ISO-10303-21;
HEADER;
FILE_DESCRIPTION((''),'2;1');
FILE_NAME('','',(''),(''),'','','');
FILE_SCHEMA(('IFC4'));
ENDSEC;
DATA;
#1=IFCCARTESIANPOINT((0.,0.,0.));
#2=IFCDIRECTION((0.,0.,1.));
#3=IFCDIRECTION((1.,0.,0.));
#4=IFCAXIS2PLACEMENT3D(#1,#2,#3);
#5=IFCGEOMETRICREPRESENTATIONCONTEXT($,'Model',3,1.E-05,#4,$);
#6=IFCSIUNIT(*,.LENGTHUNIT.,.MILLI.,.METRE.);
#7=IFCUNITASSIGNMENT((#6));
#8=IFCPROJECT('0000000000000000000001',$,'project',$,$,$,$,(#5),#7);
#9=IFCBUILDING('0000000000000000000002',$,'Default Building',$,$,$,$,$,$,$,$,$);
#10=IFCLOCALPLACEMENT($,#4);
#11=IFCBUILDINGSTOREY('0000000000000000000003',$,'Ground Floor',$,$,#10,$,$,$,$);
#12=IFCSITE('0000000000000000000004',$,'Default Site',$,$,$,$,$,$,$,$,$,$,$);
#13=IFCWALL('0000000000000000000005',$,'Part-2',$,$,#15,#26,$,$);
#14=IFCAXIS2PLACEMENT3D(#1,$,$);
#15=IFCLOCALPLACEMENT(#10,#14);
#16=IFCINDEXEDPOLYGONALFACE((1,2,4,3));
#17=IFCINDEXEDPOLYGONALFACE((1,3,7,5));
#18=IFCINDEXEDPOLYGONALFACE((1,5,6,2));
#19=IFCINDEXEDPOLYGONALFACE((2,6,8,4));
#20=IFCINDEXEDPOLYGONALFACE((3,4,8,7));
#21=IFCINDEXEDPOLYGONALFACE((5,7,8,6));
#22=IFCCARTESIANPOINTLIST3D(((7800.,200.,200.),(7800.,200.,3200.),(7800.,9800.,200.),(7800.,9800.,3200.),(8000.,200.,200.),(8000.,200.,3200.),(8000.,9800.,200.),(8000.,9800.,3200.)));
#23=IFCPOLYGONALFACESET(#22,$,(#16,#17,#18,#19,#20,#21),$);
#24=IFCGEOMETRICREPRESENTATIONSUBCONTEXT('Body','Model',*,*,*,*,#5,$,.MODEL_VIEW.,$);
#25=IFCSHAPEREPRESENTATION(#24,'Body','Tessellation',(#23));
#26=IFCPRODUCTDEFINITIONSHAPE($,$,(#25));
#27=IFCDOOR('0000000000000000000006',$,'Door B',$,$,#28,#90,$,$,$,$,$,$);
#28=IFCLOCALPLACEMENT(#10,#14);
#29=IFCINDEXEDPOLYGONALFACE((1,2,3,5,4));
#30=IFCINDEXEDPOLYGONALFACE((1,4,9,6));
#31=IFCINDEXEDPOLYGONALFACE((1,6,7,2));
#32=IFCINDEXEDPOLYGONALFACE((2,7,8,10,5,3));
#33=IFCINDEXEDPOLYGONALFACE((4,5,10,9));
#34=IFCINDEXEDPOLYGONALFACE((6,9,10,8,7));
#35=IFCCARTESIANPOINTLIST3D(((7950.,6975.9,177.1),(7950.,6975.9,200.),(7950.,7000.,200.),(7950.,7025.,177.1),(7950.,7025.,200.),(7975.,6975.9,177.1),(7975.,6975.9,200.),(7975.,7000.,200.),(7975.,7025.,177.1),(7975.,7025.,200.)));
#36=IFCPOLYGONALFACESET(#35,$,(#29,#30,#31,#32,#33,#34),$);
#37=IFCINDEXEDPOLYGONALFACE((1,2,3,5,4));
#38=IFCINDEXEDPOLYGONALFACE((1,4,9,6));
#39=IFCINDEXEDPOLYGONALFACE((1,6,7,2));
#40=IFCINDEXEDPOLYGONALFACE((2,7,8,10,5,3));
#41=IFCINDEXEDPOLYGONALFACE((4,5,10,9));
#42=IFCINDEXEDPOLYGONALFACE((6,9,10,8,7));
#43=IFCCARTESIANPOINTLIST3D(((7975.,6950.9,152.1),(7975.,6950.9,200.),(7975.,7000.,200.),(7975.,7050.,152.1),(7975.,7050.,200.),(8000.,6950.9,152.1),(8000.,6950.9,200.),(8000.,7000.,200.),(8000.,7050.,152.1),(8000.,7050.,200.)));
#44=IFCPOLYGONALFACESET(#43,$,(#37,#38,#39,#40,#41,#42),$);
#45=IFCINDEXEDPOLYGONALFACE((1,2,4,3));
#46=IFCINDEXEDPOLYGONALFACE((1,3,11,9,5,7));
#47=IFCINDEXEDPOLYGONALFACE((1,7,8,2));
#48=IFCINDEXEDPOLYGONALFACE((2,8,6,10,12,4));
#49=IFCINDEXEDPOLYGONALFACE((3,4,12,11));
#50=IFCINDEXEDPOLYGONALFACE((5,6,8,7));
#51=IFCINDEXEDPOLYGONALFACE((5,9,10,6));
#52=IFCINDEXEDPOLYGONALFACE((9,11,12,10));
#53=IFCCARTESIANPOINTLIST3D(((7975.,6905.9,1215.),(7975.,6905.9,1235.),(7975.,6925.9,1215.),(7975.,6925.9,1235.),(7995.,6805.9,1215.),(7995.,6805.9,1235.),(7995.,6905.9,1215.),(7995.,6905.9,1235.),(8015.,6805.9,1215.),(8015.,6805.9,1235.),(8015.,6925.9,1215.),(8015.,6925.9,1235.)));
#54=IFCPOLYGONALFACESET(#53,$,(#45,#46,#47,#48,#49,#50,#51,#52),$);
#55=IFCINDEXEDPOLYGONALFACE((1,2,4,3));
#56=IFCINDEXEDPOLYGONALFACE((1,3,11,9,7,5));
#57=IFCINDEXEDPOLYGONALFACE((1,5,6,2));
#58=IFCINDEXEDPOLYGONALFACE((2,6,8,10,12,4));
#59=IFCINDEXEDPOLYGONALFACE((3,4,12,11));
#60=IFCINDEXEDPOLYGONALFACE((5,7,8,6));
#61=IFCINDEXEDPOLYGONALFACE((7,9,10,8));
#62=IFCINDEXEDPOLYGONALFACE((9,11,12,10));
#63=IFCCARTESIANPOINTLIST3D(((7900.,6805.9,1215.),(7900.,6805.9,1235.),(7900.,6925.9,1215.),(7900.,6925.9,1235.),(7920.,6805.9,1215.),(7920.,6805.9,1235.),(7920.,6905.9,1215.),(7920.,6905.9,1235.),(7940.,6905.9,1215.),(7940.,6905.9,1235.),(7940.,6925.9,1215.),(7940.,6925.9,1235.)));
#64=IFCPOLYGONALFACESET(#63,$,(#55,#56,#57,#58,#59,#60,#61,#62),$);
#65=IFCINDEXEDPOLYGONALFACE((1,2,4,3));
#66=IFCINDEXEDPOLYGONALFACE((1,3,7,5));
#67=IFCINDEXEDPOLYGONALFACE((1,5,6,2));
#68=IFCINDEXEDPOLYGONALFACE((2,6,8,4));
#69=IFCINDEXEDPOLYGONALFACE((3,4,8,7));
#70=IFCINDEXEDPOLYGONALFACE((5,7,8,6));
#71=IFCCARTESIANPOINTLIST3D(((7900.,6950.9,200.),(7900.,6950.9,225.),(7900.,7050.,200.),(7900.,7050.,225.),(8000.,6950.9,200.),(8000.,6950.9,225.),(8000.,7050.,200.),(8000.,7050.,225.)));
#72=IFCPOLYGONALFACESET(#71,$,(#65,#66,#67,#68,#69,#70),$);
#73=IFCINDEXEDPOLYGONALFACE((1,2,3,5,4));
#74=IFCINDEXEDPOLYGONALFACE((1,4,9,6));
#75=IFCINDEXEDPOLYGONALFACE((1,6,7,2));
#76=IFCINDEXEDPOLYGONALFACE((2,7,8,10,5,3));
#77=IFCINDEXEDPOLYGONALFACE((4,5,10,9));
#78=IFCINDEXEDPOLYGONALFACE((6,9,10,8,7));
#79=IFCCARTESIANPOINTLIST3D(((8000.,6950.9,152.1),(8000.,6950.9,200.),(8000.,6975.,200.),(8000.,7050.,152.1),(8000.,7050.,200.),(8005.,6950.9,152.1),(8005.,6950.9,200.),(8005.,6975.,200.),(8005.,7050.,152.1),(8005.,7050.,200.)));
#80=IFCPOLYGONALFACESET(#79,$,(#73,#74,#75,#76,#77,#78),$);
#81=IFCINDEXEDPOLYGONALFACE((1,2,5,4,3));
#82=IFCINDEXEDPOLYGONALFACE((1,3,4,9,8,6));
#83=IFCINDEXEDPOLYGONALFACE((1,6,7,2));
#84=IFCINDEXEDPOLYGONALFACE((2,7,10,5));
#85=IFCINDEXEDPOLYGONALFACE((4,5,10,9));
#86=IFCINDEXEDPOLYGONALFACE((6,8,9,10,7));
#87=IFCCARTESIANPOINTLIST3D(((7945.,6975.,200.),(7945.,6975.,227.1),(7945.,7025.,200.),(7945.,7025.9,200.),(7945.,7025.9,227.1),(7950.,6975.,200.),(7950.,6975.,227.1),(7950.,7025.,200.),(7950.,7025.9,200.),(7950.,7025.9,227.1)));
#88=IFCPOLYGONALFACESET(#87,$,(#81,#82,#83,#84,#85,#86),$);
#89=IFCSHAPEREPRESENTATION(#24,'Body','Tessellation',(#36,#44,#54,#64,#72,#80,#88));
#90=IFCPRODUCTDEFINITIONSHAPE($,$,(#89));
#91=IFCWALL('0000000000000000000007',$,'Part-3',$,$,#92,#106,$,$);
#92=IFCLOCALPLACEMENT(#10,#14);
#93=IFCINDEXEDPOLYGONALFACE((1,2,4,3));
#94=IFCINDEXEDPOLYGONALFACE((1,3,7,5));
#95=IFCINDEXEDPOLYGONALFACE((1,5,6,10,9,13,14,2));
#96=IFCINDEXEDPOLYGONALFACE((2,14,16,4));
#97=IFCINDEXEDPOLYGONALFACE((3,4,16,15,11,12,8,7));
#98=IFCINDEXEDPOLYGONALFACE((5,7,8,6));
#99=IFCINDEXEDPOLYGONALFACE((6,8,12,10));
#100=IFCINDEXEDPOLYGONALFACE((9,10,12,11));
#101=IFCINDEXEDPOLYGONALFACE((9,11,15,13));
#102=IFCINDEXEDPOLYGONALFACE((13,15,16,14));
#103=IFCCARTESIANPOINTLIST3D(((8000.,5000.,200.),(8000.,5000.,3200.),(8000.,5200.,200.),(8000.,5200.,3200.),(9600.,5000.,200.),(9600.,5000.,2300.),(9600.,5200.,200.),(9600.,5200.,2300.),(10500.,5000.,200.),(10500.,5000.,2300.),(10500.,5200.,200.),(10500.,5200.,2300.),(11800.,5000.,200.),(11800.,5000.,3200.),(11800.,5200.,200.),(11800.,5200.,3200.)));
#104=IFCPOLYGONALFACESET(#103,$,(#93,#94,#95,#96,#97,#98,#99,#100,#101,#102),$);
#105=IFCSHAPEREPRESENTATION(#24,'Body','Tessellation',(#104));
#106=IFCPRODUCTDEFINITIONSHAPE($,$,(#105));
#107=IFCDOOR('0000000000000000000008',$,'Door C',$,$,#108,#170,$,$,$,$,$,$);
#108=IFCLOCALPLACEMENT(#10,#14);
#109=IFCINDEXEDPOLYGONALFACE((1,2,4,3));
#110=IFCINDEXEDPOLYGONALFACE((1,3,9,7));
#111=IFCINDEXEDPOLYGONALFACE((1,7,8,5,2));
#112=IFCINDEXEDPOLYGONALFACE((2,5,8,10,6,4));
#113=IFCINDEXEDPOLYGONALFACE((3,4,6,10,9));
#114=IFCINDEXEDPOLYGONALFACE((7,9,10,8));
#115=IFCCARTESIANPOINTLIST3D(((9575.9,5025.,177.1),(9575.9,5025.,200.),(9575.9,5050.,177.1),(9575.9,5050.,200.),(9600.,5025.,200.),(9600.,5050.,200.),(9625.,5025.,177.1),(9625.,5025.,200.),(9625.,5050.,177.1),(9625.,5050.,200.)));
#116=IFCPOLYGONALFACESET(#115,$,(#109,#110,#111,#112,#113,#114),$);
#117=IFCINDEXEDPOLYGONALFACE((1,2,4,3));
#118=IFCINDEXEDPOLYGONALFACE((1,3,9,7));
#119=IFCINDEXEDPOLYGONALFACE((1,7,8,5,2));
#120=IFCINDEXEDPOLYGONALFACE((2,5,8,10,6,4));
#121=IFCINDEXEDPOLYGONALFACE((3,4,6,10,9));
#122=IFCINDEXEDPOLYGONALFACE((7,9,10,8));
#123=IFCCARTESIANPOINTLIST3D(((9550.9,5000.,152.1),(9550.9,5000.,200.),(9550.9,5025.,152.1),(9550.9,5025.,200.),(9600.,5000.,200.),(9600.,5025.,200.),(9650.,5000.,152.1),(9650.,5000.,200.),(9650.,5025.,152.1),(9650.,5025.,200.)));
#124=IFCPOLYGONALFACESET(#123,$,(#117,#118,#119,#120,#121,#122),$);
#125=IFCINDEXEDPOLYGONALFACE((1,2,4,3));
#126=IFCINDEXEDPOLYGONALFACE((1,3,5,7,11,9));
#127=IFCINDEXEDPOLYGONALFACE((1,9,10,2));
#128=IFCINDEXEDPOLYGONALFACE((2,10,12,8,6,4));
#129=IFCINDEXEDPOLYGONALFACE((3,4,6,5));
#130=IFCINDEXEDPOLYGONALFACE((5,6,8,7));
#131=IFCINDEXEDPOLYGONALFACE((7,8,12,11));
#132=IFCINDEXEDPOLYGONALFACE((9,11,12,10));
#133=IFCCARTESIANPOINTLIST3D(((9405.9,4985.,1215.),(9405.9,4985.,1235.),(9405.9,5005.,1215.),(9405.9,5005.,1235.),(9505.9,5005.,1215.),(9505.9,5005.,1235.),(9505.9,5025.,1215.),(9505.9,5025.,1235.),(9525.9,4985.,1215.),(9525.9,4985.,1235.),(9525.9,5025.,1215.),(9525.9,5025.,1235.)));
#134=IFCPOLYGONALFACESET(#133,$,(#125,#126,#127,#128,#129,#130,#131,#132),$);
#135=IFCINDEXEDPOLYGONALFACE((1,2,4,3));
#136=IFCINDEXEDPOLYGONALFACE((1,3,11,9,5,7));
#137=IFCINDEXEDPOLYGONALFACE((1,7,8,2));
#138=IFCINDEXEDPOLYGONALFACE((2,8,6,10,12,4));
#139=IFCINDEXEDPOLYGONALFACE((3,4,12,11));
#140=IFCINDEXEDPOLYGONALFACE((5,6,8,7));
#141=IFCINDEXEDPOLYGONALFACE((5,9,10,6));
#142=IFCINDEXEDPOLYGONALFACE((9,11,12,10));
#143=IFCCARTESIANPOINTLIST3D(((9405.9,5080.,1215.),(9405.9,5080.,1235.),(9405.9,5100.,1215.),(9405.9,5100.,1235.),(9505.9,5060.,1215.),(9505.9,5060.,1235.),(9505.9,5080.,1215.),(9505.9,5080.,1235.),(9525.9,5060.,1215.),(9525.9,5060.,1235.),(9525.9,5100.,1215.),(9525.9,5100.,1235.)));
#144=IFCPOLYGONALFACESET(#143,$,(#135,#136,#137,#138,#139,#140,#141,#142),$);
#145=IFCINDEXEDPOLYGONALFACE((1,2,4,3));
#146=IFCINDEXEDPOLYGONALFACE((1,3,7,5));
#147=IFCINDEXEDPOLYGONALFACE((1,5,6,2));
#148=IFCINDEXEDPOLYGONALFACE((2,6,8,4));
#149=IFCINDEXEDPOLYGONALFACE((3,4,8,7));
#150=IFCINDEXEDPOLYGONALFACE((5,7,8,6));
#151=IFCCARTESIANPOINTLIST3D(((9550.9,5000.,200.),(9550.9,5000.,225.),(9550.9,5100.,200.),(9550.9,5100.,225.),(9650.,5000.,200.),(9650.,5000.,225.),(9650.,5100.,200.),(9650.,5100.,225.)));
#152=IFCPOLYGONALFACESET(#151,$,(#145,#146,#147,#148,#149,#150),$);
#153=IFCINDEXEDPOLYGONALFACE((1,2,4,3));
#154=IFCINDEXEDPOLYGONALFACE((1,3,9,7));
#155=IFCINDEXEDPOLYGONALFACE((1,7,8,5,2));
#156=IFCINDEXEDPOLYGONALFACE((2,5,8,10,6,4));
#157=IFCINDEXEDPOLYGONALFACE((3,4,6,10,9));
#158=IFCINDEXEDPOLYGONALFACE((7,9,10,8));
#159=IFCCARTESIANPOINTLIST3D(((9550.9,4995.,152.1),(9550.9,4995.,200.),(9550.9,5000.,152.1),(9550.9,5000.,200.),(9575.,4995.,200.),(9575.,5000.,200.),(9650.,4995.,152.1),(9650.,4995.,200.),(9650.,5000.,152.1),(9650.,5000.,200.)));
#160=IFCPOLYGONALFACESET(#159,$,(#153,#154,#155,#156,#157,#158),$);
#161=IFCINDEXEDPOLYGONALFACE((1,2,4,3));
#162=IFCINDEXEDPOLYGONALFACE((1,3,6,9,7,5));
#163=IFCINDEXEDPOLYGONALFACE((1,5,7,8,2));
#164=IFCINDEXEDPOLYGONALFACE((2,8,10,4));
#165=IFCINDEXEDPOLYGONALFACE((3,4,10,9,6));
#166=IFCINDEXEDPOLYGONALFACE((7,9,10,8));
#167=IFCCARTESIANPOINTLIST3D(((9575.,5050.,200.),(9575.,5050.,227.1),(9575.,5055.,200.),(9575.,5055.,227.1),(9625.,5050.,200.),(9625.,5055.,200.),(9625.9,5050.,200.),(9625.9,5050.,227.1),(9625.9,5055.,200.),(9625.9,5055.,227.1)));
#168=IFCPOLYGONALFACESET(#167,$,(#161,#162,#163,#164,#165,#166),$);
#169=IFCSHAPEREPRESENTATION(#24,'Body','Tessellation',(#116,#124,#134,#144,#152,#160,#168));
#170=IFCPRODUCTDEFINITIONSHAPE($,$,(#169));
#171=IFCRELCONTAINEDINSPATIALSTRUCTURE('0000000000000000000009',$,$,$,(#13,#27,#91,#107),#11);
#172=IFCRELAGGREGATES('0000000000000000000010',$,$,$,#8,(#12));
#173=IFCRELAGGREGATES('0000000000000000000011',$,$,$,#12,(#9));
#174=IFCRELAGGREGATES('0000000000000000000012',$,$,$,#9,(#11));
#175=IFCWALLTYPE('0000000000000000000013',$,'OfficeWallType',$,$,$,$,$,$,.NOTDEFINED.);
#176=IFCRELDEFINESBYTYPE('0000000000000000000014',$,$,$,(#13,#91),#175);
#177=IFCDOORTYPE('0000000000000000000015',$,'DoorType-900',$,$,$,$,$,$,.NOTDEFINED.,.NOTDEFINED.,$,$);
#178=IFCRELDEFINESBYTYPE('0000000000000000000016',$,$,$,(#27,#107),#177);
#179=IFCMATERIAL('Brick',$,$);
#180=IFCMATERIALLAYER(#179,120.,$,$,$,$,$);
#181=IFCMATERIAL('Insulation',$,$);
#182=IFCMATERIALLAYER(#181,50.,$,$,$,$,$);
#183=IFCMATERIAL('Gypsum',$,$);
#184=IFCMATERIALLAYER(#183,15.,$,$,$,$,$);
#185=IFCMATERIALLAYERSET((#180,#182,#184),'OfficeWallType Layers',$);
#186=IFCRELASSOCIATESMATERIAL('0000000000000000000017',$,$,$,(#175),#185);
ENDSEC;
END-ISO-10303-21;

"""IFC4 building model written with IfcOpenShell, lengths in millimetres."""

from ifc_helpers import new_model, si_unit, frame, origin_with_axes, place, context, subcontext, project, spatial, line, indexed_curve, outline, extrude, material, layer, layer_set, type_object, element, fill, save


model = new_model("IFC4")

# Units and contexts
model_context = context("Model", 3, precision=1e-05, world=origin_with_axes())
body_context = subcontext(model_context, "Body", "Model", "MODEL_VIEW")
ifc_project = project(units=[si_unit("LENGTHUNIT", "METRE", prefix="MILLI")], contexts=[model_context])

# Site, building, storey
site = spatial("IfcSite", under=ifc_project, Name="Default Site")
building = spatial("IfcBuilding", under=site, Name="Default Building")
storey_placement = place(None, origin_with_axes())
storey = spatial("IfcBuildingStorey", under=building, at=storey_placement, Name="Ground Floor")

# Shared definitions
ifc_material_1 = material(Name="Brick")
ifc_layer_1 = layer(ifc_material_1, 120.0)
ifc_material_2 = material(Name="Insulation")
ifc_layer_2 = layer(ifc_material_2, 50.0)
ifc_material_3 = material(Name="Gypsum")
ifc_layer_3 = layer(ifc_material_3, 15.0)
ifc_layer_set_1 = layer_set([ifc_layer_1, ifc_layer_2, ifc_layer_3], Name="OfficeWallType Layers")
wall_type = type_object("IfcWallType", Name="OfficeWallType", PredefinedType="NOTDEFINED", material=ifc_layer_set_1)
door_type = type_object("IfcDoorType", Name="DoorType-900", OperationType="NOTDEFINED", PredefinedType="NOTDEFINED")

# Walls, openings, doors
wall_1_placement = place(storey_placement, frame((0.0, 0.0, 200.0), z_axis=(0.0, 0.0, 1.0), x_axis=(1.0, 0.0, 0.0)))
wall_1 = element("IfcWall", 1, at=wall_1_placement, inside=storey, type_object=wall_type, Name="Part-2", context=body_context, shape_type="SweptSolid", body=[
    extrude(outline(indexed_curve([(8000.0, 200.0), (8000.0, 9800.0), (7800.0, 9800.0), (7800.0, 200.0), (8000.0, 200.0)])), None, (0.0, 0.0, 1.0), 3000.0),
])
opening_1_placement = place(wall_1_placement, origin_with_axes())
opening_1 = element("IfcOpeningElement", 2, at=opening_1_placement, cuts=wall_1, context=body_context, shape_type="SweptSolid", body=[
    extrude(outline(indexed_curve([(8000.0, 7000.0), (8200.0, 7000.0), (8200.0, 7900.0), (8000.0, 7900.0), (8000.0, 7000.0)])), None, (0.0, 0.0, 1.0), 2100.0),
])
door_1_placement = place(storey_placement, frame((8000.0, 7000.0, 200.0), z_axis=(0.0, 0.0, 1.0), x_axis=(0.0, 1.0, 0.0)))
door_1 = element("IfcDoor", 3, at=door_1_placement, inside=storey, type_object=door_type, Name="Door B", context=body_context, shape_type="SweptSolid", body=[
    extrude(outline(indexed_curve([(0.0, 0.0), (0.0, 2.1), (0.9, 2.1), (0.9, 0.0), (-24.1, 0.0), (-24.1, -22.9), (25.0, -22.9), (25.0, 0.0)], segments=[line(1, 2, 3, 4, 5, 6, 7, 8, 1)])), frame((0.0, 25.0, 0.0), z_axis=(0.0, -1.0, 0.0), x_axis=(1.0, 0.0, 0.0)), (0.0, 0.0, -1.0), 25.0),
    extrude(outline(indexed_curve([(0.0, 0.0), (0.0, 2.1), (0.9, 2.1), (0.9, 0.0), (-49.1, 0.0), (-49.1, -47.9), (50.0, -47.9), (50.0, 0.0)], segments=[line(1, 2, 3, 4, 5, 6, 7, 8, 1)])), frame((0.0, 0.0, 0.0), z_axis=(0.0, -1.0, 0.0), x_axis=(1.0, 0.0, 0.0)), (0.0, 0.0, -1.0), 25.0),
    extrude(outline(indexed_curve([(0.0, 0.0), (-49.1, 0.0), (-49.1, 35.0), (0.0, 35.0)], segments=[line(1, 2, 3, 4, 1)])), frame((25.0, 25.0, 25.0), z_axis=(0.0, 0.0, 1.0), x_axis=(1.0, 0.0, 0.0)), (0.0, 0.0, 1.0), -47.9),
    extrude(outline(indexed_curve([(0.0, 0.0), (0.0, -40.0), (-120.0, -40.0), (-120.0, -20.0), (-20.0, -20.0), (-20.0, 0.0)], segments=[line(1, 2, 3, 4, 5, 6, 1)])), frame((-74.1, 25.0, 1015.0), z_axis=(0.0, 0.0, 1.0), x_axis=(1.0, 0.0, 0.0)), (0.0, 0.0, 1.0), 20.0),
    extrude(outline(indexed_curve([(0.0, 0.0), (0.0, 40.0), (-120.0, 40.0), (-120.0, 20.0), (-20.0, 20.0), (-20.0, 0.0)], segments=[line(1, 2, 3, 4, 5, 6, 1)])), frame((-74.1, 60.0, 1015.0), z_axis=(0.0, 0.0, 1.0), x_axis=(1.0, 0.0, 0.0)), (0.0, 0.0, 1.0), 20.0),
    extrude(outline(indexed_curve([(0.0, 0.0), (-99.1, 0.0), (-99.1, 100.0), (0.0, 100.0)], segments=[line(1, 2, 3, 4, 1)])), frame((50.0, 0.0, 0.0), z_axis=(0.0, 0.0, 1.0), x_axis=(1.0, 0.0, 0.0)), (0.0, 0.0, 1.0), 25.0),
    extrude(outline(indexed_curve([(0.0, 0.0), (0.0, 27.1), (50.9, 27.1), (50.9, 0.0), (-24.1, 0.0), (-24.1, -47.9), (75.0, -47.9), (75.0, 0.0)], segments=[line(1, 2, 3, 4, 5, 6, 7, 8, 1)])), frame((-25.0, -5.0, 0.0), z_axis=(0.0, -1.0, 0.0), x_axis=(1.0, 0.0, 0.0)), (0.0, 0.0, -1.0), 5.0),
    extrude(outline(indexed_curve([(0.0, 0.0), (0.0, 27.1), (50.9, 27.1), (50.9, 0.0), (0.9, 0.0), (0.9, -22.9), (50.0, -22.9), (50.0, 0.0)], segments=[line(1, 2, 3, 4, 5, 6, 7, 8, 1)])), frame((-25.0, 50.0, 0.0), z_axis=(0.0, -1.0, 0.0), x_axis=(1.0, 0.0, 0.0)), (0.0, 0.0, -1.0), 5.0),
])
fill(opening_1, door_1)
wall_2_placement = place(storey_placement, frame((0.0, 0.0, 200.0), z_axis=(0.0, 0.0, 1.0), x_axis=(1.0, 0.0, 0.0)))
wall_2 = element("IfcWall", 4, at=wall_2_placement, inside=storey, type_object=wall_type, Name="Part-3", context=body_context, shape_type="SweptSolid", body=[
    extrude(outline(indexed_curve([(8000.0, 5000.0), (11800.0, 5000.0), (11800.0, 5200.0), (8000.0, 5200.0), (8000.0, 5000.0)])), None, (0.0, 0.0, 1.0), 3000.0),
])
opening_2_placement = place(wall_2_placement, origin_with_axes())
opening_2 = element("IfcOpeningElement", 5, at=opening_2_placement, cuts=wall_2, context=body_context, shape_type="SweptSolid", body=[
    extrude(outline(indexed_curve([(9600.0, 5000.0), (10500.0, 5000.0), (10500.0, 5200.0), (9600.0, 5200.0), (9600.0, 5000.0)])), None, (0.0, 0.0, 1.0), 2100.0),
])
door_2_placement = place(storey_placement, frame((9600.0, 5000.0, 200.0), z_axis=(0.0, 0.0, 1.0), x_axis=(1.0, 0.0, 0.0)))
door_2 = element("IfcDoor", 6, at=door_2_placement, inside=storey, type_object=door_type, Name="Door C", context=body_context, shape_type="SweptSolid", body=[
    extrude(outline(indexed_curve([(0.0, 0.0), (0.0, 2.1), (0.9, 2.1), (0.9, 0.0), (-24.1, 0.0), (-24.1, -22.9), (25.0, -22.9), (25.0, 0.0)], segments=[line(1, 2, 3, 4, 5, 6, 7, 8, 1)])), frame((0.0, 25.0, 0.0), z_axis=(0.0, -1.0, 0.0), x_axis=(1.0, 0.0, 0.0)), (0.0, 0.0, -1.0), 25.0),
    extrude(outline(indexed_curve([(0.0, 0.0), (0.0, 2.1), (0.9, 2.1), (0.9, 0.0), (-49.1, 0.0), (-49.1, -47.9), (50.0, -47.9), (50.0, 0.0)], segments=[line(1, 2, 3, 4, 5, 6, 7, 8, 1)])), frame((0.0, 0.0, 0.0), z_axis=(0.0, -1.0, 0.0), x_axis=(1.0, 0.0, 0.0)), (0.0, 0.0, -1.0), 25.0),
    extrude(outline(indexed_curve([(0.0, 0.0), (-49.1, 0.0), (-49.1, 35.0), (0.0, 35.0)], segments=[line(1, 2, 3, 4, 1)])), frame((25.0, 25.0, 25.0), z_axis=(0.0, 0.0, 1.0), x_axis=(1.0, 0.0, 0.0)), (0.0, 0.0, 1.0), -47.9),
    extrude(outline(indexed_curve([(0.0, 0.0), (0.0, -40.0), (-120.0, -40.0), (-120.0, -20.0), (-20.0, -20.0), (-20.0, 0.0)], segments=[line(1, 2, 3, 4, 5, 6, 1)])), frame((-74.1, 25.0, 1015.0), z_axis=(0.0, 0.0, 1.0), x_axis=(1.0, 0.0, 0.0)), (0.0, 0.0, 1.0), 20.0),
    extrude(outline(indexed_curve([(0.0, 0.0), (0.0, 40.0), (-120.0, 40.0), (-120.0, 20.0), (-20.0, 20.0), (-20.0, 0.0)], segments=[line(1, 2, 3, 4, 5, 6, 1)])), frame((-74.1, 60.0, 1015.0), z_axis=(0.0, 0.0, 1.0), x_axis=(1.0, 0.0, 0.0)), (0.0, 0.0, 1.0), 20.0),
    extrude(outline(indexed_curve([(0.0, 0.0), (-99.1, 0.0), (-99.1, 100.0), (0.0, 100.0)], segments=[line(1, 2, 3, 4, 1)])), frame((50.0, 0.0, 0.0), z_axis=(0.0, 0.0, 1.0), x_axis=(1.0, 0.0, 0.0)), (0.0, 0.0, 1.0), 25.0),
    extrude(outline(indexed_curve([(0.0, 0.0), (0.0, 27.1), (50.9, 27.1), (50.9, 0.0), (-24.1, 0.0), (-24.1, -47.9), (75.0, -47.9), (75.0, 0.0)], segments=[line(1, 2, 3, 4, 5, 6, 7, 8, 1)])), frame((-25.0, -5.0, 0.0), z_axis=(0.0, -1.0, 0.0), x_axis=(1.0, 0.0, 0.0)), (0.0, 0.0, -1.0), 5.0),
    extrude(outline(indexed_curve([(0.0, 0.0), (0.0, 27.1), (50.9, 27.1), (50.9, 0.0), (0.9, 0.0), (0.9, -22.9), (50.0, -22.9), (50.0, 0.0)], segments=[line(1, 2, 3, 4, 5, 6, 7, 8, 1)])), frame((-25.0, 50.0, 0.0), z_axis=(0.0, -1.0, 0.0), x_axis=(1.0, 0.0, 0.0)), (0.0, 0.0, -1.0), 5.0),
])
fill(opening_2, door_2)

save(model, "model.ifc")
